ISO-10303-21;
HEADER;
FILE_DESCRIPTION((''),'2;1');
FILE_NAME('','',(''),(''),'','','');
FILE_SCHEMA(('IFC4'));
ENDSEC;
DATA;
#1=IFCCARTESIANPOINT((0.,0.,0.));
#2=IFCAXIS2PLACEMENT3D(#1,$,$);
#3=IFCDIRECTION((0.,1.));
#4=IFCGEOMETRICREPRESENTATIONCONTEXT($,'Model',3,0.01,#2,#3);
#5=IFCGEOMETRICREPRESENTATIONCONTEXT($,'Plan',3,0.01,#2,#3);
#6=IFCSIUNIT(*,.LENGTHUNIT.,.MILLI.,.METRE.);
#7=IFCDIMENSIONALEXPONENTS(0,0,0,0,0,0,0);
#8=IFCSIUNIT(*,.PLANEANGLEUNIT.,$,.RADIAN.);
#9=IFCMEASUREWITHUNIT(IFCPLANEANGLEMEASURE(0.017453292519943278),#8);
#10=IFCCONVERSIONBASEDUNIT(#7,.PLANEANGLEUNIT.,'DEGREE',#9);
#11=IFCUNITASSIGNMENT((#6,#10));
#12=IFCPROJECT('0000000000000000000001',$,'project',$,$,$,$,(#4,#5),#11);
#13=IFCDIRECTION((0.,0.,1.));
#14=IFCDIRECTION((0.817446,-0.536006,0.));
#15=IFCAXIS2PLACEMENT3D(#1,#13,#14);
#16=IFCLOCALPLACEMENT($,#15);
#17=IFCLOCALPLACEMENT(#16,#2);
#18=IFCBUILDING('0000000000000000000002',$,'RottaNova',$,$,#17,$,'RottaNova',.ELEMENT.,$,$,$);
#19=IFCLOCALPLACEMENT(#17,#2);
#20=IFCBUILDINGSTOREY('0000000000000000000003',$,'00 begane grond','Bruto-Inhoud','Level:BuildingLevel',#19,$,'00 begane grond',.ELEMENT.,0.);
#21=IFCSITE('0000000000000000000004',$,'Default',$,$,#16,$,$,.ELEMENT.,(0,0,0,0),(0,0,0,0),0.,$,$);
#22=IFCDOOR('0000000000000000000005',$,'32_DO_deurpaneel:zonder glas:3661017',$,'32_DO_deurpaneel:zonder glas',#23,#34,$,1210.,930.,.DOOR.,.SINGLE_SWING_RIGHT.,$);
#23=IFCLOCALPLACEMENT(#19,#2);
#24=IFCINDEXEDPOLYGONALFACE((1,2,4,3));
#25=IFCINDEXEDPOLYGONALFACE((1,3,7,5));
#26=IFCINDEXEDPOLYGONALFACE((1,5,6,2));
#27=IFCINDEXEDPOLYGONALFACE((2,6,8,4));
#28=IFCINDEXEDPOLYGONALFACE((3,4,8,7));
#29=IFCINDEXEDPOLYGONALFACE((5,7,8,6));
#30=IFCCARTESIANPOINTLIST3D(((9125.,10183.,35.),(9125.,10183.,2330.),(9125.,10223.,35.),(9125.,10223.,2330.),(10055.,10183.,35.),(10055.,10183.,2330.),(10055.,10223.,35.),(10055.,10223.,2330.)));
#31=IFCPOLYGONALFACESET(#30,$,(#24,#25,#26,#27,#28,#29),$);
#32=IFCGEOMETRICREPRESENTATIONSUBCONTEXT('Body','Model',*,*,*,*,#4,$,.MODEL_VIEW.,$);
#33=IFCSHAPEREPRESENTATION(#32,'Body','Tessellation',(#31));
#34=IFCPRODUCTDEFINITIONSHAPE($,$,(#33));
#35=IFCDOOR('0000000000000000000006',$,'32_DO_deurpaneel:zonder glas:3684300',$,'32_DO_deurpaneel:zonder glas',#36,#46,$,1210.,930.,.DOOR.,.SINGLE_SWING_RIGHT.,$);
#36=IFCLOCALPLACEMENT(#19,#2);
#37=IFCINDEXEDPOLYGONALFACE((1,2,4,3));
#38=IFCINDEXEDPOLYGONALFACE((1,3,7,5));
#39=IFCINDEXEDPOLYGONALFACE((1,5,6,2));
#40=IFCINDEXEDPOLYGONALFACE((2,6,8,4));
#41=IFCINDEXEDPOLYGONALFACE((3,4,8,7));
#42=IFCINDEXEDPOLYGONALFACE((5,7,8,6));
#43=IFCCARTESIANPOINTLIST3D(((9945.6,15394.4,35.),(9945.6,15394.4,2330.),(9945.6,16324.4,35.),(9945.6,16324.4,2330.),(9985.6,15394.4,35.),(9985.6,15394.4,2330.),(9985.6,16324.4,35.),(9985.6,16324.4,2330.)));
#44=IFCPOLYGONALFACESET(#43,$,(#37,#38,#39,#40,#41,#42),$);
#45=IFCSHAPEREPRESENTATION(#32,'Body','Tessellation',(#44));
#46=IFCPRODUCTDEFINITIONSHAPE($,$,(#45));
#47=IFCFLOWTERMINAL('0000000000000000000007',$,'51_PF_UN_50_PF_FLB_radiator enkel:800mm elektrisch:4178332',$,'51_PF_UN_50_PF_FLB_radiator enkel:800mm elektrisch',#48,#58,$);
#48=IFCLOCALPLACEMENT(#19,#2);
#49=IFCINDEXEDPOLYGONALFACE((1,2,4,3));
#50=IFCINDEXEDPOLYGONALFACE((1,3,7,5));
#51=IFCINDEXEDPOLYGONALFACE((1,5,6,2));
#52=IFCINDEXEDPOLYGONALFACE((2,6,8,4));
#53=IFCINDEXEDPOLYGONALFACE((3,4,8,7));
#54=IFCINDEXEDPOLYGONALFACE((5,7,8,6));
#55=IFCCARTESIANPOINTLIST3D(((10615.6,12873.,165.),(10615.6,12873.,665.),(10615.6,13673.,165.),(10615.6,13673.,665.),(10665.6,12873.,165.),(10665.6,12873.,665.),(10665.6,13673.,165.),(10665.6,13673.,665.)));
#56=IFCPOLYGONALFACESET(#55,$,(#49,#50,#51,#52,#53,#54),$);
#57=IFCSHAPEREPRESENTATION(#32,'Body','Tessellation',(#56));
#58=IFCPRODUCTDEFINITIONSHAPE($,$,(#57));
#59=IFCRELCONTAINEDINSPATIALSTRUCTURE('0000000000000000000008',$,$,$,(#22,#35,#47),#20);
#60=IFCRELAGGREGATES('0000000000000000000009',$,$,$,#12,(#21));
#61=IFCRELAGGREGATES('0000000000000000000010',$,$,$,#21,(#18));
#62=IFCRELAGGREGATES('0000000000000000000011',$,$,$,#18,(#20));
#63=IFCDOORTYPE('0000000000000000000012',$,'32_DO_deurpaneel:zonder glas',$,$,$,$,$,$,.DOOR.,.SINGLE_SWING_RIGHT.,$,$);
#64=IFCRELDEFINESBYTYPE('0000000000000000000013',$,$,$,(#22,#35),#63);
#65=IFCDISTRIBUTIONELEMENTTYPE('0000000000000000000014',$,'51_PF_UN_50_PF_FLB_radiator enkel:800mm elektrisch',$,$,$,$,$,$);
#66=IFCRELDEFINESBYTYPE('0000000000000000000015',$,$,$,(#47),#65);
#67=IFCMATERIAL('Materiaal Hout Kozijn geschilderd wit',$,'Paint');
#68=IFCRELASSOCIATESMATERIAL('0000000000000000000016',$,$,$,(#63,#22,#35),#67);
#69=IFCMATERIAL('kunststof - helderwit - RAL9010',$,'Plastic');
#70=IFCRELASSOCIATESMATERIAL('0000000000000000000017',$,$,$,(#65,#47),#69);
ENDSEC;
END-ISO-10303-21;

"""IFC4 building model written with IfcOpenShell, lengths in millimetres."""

from ifc_helpers import new_model, entity, si_unit, converted_unit, direction, frame, origin, place, context, subcontext, project, spatial, indexed_curve, outline, extrude, source, transform, mapped, material, type_object, type_shapes, element, save


model = new_model("IFC4")

# Units and contexts
model_context = context("Model", 3, precision=0.01, world=origin(), true_north=direction((0.0, 1.0)))
plan_context = context("Plan", 3, precision=0.01, world=origin(), true_north=direction((0.0, 1.0)))
body_context = subcontext(model_context, "Body", "Model", "MODEL_VIEW")
ifc_project = project(units=[si_unit("LENGTHUNIT", "METRE", prefix="MILLI"), converted_unit("PLANEANGLEUNIT", "DEGREE", entity("IfcPlaneAngleMeasure", 0.017453292519943278), si_unit("PLANEANGLEUNIT", "RADIAN"), dimensions=[0, 0, 0, 0, 0, 0, 0])], contexts=[model_context, plan_context])

# Site, building, storey
site_placement = place(None, frame((0.0, 0.0, 0.0), z_axis=(0.0, 0.0, 1.0), x_axis=(0.817446, -0.536006, 0.0)))
site = spatial("IfcSite", under=ifc_project, at=site_placement, Name="Default", CompositionType="ELEMENT", RefLatitude=(0, 0, 0, 0), RefLongitude=(0, 0, 0, 0), RefElevation=0.0)
building_placement = place(site_placement, origin())
building = spatial("IfcBuilding", under=site, at=building_placement, Name="RottaNova", LongName="RottaNova", CompositionType="ELEMENT")
storey_placement = place(building_placement, origin())
storey = spatial("IfcBuildingStorey", under=building, at=storey_placement, Name="00 begane grond", Description="Bruto-Inhoud", ObjectType="Level:BuildingLevel", LongName="00 begane grond", CompositionType="ELEMENT", Elevation=0.0)

# Doors
ifc_material_1 = material(Name="Materiaal Hout Kozijn geschilderd wit", Category="Paint")
door_type_1 = type_object("IfcDoorType", Name="32_DO_deurpaneel:zonder glas", OperationType="SINGLE_SWING_RIGHT", PredefinedType="DOOR", material=ifc_material_1)
shared_shape_1 = source(origin(), body_context, "Body", "SweptSolid", [
    extrude(outline(indexed_curve([(-20.0, -1147.5), (20.0, -1147.5), (20.0, 1147.5), (-20.0, 1147.5), (-20.0, -1147.5)], self_intersect=False)), frame((-465.0, -20.0, 1182.5), z_axis=(1.0, 0.0, 0.0), x_axis=(0.0, 1.0, 0.0)), (0.0, 0.0, 1.0), 930.0),
])
type_shapes(door_type_1, [shared_shape_1])
door_1_placement = place(storey_placement, frame((9590.0, 10223.0, 0.0)))
element("IfcDoor", 1, at=door_1_placement, inside=storey, type_object=door_type_1, material=ifc_material_1, Name="32_DO_deurpaneel:zonder glas:3661017", ObjectType="32_DO_deurpaneel:zonder glas", OperationType="SINGLE_SWING_RIGHT", OverallHeight=1210.0, OverallWidth=930.0, PredefinedType="DOOR", context=body_context, shape_type="MappedRepresentation", body=[
    mapped(shared_shape_1, transform((0.0, 0.0, 0.0), scale=1.0)),
])
door_2_placement = place(storey_placement, frame((9985.6, 15859.4, 0.0), z_axis=(0.0, 0.0, 1.0), x_axis=(0.0, -1.0, 0.0)))
element("IfcDoor", 2, at=door_2_placement, inside=storey, type_object=door_type_1, material=ifc_material_1, Name="32_DO_deurpaneel:zonder glas:3684300", ObjectType="32_DO_deurpaneel:zonder glas", OperationType="SINGLE_SWING_RIGHT", OverallHeight=1210.0, OverallWidth=930.0, PredefinedType="DOOR", context=body_context, shape_type="MappedRepresentation", body=[
    mapped(shared_shape_1, transform((0.0, 0.0, 0.0), scale=1.0)),
])

# Flow terminal
ifc_material_2 = material(Name="kunststof - helderwit - RAL9010", Category="Plastic")
distribution_element_type = type_object("IfcDistributionElementType", Name="51_PF_UN_50_PF_FLB_radiator enkel:800mm elektrisch", material=ifc_material_2)
shared_shape_2 = source(origin(), body_context, "Body", "SweptSolid", [
    extrude(outline(indexed_curve([(-400.0, -25.0), (400.0, -25.0), (400.0, 25.0), (-400.0, 25.0), (-400.0, -25.0)], self_intersect=False)), frame((0.0, 75.0, 150.0), z_axis=(0.0, 0.0, 1.0), x_axis=(-1.0, 0.0, 0.0)), (0.0, 0.0, 1.0), 500.0),
])
type_shapes(distribution_element_type, [shared_shape_2])
flow_terminal_placement = place(storey_placement, frame((10565.6, 13273.0, 15.0), z_axis=(0.0, 0.0, 1.0), x_axis=(0.0, -1.0, 0.0)))
element("IfcFlowTerminal", 3, at=flow_terminal_placement, inside=storey, type_object=distribution_element_type, material=ifc_material_2, Name="51_PF_UN_50_PF_FLB_radiator enkel:800mm elektrisch:4178332", ObjectType="51_PF_UN_50_PF_FLB_radiator enkel:800mm elektrisch", context=body_context, shape_type="MappedRepresentation", body=[
    mapped(shared_shape_2, transform((0.0, 0.0, 0.0), scale=1.0)),
])

save(model, "model.ifc")
